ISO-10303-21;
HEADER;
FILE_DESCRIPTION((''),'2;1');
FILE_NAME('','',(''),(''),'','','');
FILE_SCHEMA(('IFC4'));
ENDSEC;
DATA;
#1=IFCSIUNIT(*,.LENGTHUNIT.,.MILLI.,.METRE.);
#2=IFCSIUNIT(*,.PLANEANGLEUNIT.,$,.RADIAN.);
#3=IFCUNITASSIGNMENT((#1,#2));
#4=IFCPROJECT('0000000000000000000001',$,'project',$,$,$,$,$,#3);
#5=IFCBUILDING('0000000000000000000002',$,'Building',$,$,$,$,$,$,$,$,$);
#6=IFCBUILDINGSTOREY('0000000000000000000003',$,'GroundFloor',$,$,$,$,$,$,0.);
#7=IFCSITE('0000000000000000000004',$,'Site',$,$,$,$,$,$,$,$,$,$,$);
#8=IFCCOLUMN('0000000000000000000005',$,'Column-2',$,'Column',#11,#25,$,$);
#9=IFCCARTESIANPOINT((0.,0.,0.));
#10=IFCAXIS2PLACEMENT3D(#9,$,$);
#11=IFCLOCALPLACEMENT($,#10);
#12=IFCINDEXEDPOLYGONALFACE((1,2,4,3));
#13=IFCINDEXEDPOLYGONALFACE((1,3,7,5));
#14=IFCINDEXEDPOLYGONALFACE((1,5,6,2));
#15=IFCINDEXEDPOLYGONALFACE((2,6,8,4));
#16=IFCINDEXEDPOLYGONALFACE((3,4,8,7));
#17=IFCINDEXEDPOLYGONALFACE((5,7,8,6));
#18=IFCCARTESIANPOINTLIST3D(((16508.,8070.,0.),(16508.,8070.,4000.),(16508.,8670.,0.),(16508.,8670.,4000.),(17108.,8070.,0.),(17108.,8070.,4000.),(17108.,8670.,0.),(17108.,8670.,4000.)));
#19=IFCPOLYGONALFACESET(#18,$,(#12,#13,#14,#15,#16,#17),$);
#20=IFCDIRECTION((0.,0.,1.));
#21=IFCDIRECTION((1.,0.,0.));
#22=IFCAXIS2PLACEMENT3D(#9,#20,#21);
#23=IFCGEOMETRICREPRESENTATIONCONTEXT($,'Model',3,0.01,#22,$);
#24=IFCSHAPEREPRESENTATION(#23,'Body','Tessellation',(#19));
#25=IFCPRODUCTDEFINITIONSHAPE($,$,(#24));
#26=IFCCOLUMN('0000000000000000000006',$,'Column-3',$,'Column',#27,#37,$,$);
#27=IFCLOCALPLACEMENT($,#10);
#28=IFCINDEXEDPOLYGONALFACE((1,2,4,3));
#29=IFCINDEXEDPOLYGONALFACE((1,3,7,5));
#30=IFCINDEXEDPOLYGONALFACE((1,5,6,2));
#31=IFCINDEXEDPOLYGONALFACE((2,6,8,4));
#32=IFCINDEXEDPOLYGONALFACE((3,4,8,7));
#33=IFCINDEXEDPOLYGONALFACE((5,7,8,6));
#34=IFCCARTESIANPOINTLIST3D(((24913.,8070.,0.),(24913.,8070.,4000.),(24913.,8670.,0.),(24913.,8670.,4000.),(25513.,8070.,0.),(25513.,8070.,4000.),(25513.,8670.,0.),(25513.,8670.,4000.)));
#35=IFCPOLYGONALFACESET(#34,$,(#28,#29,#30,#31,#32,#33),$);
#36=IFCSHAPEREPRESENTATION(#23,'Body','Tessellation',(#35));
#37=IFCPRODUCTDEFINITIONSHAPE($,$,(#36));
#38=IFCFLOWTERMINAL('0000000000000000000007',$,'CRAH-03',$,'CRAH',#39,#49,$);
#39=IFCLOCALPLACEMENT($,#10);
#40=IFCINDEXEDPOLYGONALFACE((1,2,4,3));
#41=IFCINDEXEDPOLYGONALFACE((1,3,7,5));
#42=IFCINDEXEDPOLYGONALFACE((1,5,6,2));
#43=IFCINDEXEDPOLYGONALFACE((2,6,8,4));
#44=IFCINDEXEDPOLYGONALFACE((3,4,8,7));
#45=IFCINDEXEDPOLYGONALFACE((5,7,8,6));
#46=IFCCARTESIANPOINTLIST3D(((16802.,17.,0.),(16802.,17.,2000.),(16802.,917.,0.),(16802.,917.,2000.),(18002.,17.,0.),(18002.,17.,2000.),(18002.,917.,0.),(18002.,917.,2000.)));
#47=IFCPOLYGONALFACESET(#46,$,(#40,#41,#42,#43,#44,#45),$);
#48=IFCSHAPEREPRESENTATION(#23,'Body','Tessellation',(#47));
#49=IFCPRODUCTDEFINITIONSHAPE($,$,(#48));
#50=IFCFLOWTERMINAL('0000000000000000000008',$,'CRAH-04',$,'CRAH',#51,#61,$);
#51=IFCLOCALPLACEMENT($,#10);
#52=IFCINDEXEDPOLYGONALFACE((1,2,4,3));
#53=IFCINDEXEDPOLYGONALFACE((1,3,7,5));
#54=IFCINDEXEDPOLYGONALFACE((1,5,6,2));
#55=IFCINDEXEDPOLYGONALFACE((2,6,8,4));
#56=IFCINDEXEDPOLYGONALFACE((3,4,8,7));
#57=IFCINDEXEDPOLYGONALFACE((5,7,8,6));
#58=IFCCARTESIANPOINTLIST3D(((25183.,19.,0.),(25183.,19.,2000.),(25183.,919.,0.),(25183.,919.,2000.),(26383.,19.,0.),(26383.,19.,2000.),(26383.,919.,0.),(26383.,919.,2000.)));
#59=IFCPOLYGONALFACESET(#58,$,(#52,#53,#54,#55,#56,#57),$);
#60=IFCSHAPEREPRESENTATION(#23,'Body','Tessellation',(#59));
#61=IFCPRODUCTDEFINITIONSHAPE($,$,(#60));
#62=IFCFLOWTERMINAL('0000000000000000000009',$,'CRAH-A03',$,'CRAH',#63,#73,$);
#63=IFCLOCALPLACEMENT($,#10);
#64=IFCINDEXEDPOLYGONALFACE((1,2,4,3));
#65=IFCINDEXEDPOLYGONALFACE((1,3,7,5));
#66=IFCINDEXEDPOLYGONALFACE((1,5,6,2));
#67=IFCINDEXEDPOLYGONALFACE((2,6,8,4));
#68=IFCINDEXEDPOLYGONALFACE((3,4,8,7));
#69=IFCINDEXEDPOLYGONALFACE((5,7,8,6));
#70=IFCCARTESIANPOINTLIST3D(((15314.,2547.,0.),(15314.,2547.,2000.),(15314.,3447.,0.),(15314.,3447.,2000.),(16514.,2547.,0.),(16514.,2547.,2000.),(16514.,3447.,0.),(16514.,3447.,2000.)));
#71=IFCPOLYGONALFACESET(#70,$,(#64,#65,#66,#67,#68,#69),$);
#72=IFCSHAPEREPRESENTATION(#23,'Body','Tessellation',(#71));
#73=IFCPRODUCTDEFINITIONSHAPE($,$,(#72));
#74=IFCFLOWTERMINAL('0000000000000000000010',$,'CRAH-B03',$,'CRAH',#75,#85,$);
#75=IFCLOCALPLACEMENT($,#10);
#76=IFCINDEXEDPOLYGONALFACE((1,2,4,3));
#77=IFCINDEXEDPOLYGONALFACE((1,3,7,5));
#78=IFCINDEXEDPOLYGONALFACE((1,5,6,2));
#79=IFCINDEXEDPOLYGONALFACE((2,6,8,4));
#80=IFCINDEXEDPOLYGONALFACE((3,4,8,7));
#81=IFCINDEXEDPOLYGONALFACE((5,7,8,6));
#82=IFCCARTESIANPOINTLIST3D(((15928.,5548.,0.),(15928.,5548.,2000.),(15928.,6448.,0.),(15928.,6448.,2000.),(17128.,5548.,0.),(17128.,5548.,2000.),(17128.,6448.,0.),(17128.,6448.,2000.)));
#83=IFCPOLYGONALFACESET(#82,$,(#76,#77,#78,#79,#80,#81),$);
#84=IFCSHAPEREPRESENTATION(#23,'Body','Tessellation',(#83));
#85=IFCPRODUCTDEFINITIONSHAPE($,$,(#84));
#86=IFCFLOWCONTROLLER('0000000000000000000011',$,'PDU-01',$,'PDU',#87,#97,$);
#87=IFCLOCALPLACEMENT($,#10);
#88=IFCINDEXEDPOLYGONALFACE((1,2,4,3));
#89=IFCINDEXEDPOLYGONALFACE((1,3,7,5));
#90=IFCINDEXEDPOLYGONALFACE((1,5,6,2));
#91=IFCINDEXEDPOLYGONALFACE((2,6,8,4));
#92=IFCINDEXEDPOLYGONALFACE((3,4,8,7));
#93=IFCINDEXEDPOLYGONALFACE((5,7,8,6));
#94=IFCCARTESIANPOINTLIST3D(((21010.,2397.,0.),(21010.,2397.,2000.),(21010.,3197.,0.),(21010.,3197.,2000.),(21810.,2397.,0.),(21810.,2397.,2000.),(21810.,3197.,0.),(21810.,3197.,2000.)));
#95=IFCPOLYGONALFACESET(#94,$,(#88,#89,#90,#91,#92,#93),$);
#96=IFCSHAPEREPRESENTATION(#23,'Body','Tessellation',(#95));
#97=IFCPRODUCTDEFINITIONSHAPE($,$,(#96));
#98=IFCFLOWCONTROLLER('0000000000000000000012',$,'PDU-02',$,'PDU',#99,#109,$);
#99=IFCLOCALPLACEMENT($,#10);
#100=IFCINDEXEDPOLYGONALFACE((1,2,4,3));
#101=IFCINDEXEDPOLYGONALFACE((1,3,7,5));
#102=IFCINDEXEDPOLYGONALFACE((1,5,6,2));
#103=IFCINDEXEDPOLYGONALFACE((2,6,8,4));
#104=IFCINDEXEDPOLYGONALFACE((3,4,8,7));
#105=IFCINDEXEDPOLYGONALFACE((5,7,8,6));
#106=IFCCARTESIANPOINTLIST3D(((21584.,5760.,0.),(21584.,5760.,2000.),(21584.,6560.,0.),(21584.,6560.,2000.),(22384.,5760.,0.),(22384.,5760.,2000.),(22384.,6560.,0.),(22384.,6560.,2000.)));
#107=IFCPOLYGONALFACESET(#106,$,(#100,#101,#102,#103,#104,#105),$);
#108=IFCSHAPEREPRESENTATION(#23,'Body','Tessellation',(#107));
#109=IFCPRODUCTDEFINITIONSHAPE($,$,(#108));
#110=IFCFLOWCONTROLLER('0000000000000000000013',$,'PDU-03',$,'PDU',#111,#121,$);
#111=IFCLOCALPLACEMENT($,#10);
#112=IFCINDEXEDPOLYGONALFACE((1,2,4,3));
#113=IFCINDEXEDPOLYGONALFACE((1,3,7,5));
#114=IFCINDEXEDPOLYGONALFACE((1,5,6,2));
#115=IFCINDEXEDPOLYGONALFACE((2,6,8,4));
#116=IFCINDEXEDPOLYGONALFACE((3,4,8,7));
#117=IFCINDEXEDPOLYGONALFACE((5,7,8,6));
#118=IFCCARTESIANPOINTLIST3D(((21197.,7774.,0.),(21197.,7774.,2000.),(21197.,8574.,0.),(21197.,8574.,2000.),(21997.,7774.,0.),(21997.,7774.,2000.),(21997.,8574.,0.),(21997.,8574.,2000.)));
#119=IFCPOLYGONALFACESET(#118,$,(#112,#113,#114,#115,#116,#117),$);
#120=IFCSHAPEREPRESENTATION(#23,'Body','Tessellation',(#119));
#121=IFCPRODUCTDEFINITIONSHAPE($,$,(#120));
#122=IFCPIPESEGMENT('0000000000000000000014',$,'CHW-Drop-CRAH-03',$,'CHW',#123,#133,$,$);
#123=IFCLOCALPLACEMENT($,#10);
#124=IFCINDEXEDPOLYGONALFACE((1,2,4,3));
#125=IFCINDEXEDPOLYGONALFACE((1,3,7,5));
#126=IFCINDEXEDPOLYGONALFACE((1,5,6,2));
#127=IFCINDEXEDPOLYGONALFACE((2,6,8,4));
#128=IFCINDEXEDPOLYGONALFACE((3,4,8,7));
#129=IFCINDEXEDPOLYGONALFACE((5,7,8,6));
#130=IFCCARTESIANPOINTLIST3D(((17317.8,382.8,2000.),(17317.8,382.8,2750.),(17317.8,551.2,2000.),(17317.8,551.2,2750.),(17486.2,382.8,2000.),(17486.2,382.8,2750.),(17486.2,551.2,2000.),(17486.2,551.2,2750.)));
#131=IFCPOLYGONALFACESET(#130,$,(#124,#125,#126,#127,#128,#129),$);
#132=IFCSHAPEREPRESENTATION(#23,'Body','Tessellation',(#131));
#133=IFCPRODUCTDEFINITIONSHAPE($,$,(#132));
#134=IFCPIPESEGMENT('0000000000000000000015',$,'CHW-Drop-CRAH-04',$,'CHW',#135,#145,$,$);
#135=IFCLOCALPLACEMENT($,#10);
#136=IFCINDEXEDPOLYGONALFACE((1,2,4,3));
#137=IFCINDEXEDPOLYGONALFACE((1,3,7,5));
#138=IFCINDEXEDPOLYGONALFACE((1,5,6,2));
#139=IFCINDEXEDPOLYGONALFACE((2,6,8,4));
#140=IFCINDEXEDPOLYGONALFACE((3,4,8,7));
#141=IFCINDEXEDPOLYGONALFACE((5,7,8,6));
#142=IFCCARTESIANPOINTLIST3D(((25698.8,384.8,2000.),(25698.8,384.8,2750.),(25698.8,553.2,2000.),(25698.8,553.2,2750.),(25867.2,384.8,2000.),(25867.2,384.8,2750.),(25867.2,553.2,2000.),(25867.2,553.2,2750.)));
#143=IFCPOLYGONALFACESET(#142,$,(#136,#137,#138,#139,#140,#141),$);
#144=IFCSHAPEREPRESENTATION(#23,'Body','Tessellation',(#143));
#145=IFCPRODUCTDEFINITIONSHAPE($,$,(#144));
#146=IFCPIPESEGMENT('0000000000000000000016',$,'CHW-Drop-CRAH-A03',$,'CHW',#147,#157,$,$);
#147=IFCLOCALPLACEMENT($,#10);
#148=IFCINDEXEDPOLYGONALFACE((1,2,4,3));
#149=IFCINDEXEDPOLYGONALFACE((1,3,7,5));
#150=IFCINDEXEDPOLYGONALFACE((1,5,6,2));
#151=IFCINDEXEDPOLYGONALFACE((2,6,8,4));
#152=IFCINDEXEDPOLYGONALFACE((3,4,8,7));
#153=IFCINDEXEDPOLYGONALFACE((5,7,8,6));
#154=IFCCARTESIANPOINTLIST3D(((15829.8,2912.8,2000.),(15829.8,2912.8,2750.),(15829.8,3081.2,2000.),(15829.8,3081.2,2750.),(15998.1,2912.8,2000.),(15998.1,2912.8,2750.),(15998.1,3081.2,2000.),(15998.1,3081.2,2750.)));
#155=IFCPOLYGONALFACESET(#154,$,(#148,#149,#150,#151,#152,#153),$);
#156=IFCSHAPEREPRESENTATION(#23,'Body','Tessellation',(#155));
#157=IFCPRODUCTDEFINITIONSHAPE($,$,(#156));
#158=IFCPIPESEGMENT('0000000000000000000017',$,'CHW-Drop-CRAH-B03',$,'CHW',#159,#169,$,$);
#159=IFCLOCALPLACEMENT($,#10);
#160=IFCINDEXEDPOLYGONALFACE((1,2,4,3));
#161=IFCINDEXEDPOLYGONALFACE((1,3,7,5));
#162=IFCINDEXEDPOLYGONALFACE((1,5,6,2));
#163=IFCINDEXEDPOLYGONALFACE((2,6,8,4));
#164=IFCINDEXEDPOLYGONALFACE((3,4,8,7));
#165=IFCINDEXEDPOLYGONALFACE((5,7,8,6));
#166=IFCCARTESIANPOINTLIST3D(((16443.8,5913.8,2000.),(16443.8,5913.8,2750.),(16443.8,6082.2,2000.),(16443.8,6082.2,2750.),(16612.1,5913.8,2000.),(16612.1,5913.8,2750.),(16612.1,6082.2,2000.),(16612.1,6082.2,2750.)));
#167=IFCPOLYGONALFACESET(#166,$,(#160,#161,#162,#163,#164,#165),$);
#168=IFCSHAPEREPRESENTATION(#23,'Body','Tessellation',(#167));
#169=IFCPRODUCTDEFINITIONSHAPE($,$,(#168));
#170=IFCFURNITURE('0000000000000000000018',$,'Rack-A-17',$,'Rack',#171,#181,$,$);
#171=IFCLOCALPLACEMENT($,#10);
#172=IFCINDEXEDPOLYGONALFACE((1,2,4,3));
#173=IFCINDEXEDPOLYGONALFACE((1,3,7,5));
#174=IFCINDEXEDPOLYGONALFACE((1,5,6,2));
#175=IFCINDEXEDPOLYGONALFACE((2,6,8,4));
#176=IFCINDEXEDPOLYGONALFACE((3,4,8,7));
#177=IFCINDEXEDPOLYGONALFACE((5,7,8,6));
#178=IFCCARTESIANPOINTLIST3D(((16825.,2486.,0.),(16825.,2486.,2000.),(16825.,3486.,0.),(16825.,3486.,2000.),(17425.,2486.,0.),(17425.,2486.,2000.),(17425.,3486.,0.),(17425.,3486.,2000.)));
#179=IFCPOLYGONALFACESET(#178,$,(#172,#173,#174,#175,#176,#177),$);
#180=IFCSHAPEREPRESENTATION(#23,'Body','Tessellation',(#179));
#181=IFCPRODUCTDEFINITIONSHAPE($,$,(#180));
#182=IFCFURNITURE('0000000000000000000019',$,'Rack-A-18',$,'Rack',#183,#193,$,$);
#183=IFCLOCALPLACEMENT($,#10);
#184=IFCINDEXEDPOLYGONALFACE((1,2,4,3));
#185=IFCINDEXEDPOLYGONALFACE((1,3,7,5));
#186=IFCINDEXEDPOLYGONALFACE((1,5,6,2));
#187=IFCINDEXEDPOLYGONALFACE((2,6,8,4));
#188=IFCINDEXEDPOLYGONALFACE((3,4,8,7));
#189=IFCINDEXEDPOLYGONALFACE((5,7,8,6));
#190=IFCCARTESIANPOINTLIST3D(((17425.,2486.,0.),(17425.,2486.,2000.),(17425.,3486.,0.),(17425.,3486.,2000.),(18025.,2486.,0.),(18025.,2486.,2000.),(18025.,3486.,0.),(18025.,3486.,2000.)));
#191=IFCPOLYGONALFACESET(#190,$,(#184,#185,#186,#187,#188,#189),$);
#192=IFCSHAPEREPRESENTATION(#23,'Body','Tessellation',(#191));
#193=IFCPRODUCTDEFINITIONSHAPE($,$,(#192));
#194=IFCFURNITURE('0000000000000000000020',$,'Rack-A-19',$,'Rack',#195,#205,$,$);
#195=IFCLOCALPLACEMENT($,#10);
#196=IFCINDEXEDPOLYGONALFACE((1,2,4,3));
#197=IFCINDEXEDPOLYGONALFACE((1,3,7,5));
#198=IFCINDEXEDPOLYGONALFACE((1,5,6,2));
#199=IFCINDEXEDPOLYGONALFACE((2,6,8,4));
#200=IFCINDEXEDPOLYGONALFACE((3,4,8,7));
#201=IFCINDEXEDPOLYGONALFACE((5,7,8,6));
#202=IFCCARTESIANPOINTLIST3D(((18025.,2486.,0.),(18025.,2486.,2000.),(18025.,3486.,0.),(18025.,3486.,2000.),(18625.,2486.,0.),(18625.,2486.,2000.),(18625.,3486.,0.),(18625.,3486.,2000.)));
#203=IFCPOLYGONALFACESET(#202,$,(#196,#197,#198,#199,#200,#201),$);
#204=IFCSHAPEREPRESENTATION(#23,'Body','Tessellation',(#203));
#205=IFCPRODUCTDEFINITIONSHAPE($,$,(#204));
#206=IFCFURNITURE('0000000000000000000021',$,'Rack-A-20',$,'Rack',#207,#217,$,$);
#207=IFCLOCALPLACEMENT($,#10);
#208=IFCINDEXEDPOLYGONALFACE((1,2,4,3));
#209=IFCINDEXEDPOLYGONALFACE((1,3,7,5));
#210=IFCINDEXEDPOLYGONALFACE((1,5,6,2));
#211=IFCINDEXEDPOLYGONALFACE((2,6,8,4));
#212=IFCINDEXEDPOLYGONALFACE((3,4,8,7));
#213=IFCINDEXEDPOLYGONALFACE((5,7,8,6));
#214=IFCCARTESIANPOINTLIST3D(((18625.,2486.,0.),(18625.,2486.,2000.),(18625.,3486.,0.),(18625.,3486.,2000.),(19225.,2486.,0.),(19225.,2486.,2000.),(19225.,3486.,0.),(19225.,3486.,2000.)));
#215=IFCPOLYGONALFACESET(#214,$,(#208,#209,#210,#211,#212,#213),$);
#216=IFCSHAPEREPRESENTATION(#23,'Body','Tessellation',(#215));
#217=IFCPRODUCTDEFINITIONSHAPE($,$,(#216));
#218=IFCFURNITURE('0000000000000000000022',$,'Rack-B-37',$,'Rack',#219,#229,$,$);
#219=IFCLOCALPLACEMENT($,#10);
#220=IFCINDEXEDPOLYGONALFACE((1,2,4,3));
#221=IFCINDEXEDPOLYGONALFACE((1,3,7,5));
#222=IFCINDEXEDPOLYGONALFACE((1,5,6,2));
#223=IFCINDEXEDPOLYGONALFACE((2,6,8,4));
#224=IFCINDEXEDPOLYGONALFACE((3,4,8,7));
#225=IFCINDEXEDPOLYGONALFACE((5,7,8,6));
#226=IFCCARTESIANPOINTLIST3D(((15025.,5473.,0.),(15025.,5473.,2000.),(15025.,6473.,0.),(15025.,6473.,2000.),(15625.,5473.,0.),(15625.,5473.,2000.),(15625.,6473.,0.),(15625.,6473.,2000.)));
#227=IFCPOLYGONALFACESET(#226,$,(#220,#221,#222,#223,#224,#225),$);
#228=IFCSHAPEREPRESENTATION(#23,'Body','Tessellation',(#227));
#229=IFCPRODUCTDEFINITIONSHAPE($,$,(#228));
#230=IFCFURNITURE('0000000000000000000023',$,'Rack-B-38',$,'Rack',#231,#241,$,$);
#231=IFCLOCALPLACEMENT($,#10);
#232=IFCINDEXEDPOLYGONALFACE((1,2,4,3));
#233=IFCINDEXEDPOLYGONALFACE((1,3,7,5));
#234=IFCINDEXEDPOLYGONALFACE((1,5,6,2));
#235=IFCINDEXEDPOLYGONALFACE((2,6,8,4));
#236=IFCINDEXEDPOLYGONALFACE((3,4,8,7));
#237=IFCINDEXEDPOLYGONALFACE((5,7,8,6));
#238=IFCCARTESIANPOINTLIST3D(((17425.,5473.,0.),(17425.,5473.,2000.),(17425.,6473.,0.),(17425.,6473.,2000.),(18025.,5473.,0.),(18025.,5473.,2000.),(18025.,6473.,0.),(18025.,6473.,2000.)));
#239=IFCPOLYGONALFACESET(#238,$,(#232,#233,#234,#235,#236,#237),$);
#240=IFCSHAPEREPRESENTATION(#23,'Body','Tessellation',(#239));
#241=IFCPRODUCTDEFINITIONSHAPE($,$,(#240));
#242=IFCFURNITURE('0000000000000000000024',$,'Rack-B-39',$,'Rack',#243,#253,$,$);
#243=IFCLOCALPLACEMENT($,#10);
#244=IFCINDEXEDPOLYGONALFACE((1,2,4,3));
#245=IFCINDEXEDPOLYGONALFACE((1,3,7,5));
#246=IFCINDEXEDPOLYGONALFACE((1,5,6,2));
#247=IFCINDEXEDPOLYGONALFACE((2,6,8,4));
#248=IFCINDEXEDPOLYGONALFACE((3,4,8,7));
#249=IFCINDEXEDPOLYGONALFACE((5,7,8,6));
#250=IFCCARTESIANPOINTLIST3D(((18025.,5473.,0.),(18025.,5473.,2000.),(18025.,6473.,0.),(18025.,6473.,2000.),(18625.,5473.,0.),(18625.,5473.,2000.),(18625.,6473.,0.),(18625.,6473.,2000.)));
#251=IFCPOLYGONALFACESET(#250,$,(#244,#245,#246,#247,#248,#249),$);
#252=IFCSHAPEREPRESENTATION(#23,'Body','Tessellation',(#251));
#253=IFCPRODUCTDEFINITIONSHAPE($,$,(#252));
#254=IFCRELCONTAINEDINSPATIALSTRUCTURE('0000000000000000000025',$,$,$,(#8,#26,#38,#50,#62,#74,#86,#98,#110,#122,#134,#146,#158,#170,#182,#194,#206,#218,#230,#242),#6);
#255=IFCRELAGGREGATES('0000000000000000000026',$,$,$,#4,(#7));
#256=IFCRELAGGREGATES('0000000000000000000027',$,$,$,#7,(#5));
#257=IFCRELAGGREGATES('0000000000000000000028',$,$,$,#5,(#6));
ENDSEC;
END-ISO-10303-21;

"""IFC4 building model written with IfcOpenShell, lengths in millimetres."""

from ifc_helpers import new_model, si_unit, frame, origin, origin_with_axes, origin_2d, place, context, project, spatial, rectangle, extrude, element, save


model = new_model("IFC4")

# Units and contexts
model_context = context("Model", 3, precision=0.01, world=origin_with_axes())
ifc_project = project(units=[si_unit("LENGTHUNIT", "METRE", prefix="MILLI"), si_unit("PLANEANGLEUNIT", "RADIAN")])

# Site, building, storey
site = spatial("IfcSite", under=ifc_project, Name="Site")
building = spatial("IfcBuilding", under=site, Name="Building")
storey = spatial("IfcBuildingStorey", under=building, Name="GroundFloor", Elevation=0.0)

# Columns
for number, where, z_axis, x_axis, name in (
    (1, (16808.0, 8370.0, 0.0), (0.0, 0.0, 1.0), (1.0, 0.0, 0.0), "Column-2"),
    (2, (25213.0, 8370.0, 0.0), (0.0, 0.0, 1.0), (1.0, 0.0, 0.0), "Column-3"),
):
    element("IfcColumn", number, at=place(None, frame(where, z_axis=z_axis, x_axis=x_axis)), inside=storey, Name=name, ObjectType="Column", context=model_context, shape_type="SweptSolid", body=[
        extrude(rectangle(XDim=600.0, YDim=600.0, at=origin_2d()), origin(), (0.0, 0.0, 1.0), 4000.0),
    ])

# Flow terminals
for number, where, z_axis, x_axis, name in (
    (3, (17402.0, 467.0, 0.0), (0.0, 0.0, 1.0), (1.0, 0.0, 0.0), "CRAH-03"),
    (4, (25783.0, 469.0, 0.0), (0.0, 0.0, 1.0), (1.0, 0.0, 0.0), "CRAH-04"),
    (5, (15914.0, 2997.0, 0.0), (0.0, 0.0, 1.0), (1.0, 0.0, 0.0), "CRAH-A03"),
    (6, (16528.0, 5998.0, 0.0), (0.0, 0.0, 1.0), (1.0, 0.0, 0.0), "CRAH-B03"),
):
    element("IfcFlowTerminal", number, at=place(None, frame(where, z_axis=z_axis, x_axis=x_axis)), inside=storey, Name=name, ObjectType="CRAH", context=model_context, shape_type="SweptSolid", body=[
        extrude(rectangle(XDim=1200.0, YDim=900.0, at=origin_2d()), origin(), (0.0, 0.0, 1.0), 2000.0),
    ])

# Flow controllers
for number, where, z_axis, x_axis, name in (
    (7, (21410.0, 2797.0, 0.0), (0.0, 0.0, 1.0), (1.0, 0.0, 0.0), "PDU-01"),
    (8, (21984.0, 6160.0, 0.0), (0.0, 0.0, 1.0), (1.0, 0.0, 0.0), "PDU-02"),
    (9, (21597.0, 8174.0, 0.0), (0.0, 0.0, 1.0), (1.0, 0.0, 0.0), "PDU-03"),
):
    element("IfcFlowController", number, at=place(None, frame(where, z_axis=z_axis, x_axis=x_axis)), inside=storey, Name=name, ObjectType="PDU", context=model_context, shape_type="SweptSolid", body=[
        extrude(rectangle(XDim=800.0, YDim=800.0, at=origin_2d()), origin(), (0.0, 0.0, 1.0), 2000.0),
    ])

# Pipe segments
for number, where, z_axis, x_axis, name in (
    (10, (17402.0, 467.0, 2000.0), (0.0, 0.0, 1.0), (1.0, 0.0, 0.0), "CHW-Drop-CRAH-03"),
    (11, (25783.0, 469.0, 2000.0), (0.0, 0.0, 1.0), (1.0, 0.0, 0.0), "CHW-Drop-CRAH-04"),
    (12, (15914.0, 2997.0, 2000.0), (0.0, 0.0, 1.0), (1.0, 0.0, 0.0), "CHW-Drop-CRAH-A03"),
    (13, (16528.0, 5998.0, 2000.0), (0.0, 0.0, 1.0), (1.0, 0.0, 0.0), "CHW-Drop-CRAH-B03"),
):
    element("IfcPipeSegment", number, at=place(None, frame(where, z_axis=z_axis, x_axis=x_axis)), inside=storey, Name=name, ObjectType="CHW", context=model_context, shape_type="SweptSolid", body=[
        extrude(rectangle(XDim=168.3, YDim=168.3, at=origin_2d()), origin(), (0.0, 0.0, 1.0), 750.0),
    ])

# Furniture
for number, where, z_axis, x_axis, name in (
    (14, (17125.0, 2986.0, 0.0), (0.0, 0.0, 1.0), (1.0, 0.0, 0.0), "Rack-A-17"),
    (15, (17725.0, 2986.0, 0.0), (0.0, 0.0, 1.0), (1.0, 0.0, 0.0), "Rack-A-18"),
    (16, (18325.0, 2986.0, 0.0), (0.0, 0.0, 1.0), (1.0, 0.0, 0.0), "Rack-A-19"),
    (17, (18925.0, 2986.0, 0.0), (0.0, 0.0, 1.0), (1.0, 0.0, 0.0), "Rack-A-20"),
    (18, (15325.0, 5973.0, 0.0), (0.0, 0.0, 1.0), (1.0, 0.0, 0.0), "Rack-B-37"),
    (19, (17725.0, 5973.0, 0.0), (0.0, 0.0, 1.0), (1.0, 0.0, 0.0), "Rack-B-38"),
    (20, (18325.0, 5973.0, 0.0), (0.0, 0.0, 1.0), (1.0, 0.0, 0.0), "Rack-B-39"),
):
    element("IfcFurniture", number, at=place(None, frame(where, z_axis=z_axis, x_axis=x_axis)), inside=storey, Name=name, ObjectType="Rack", context=model_context, shape_type="SweptSolid", body=[
        extrude(rectangle(XDim=600.0, YDim=1000.0, at=origin_2d()), origin(), (0.0, 0.0, 1.0), 2000.0),
    ])

save(model, "model.ifc")
